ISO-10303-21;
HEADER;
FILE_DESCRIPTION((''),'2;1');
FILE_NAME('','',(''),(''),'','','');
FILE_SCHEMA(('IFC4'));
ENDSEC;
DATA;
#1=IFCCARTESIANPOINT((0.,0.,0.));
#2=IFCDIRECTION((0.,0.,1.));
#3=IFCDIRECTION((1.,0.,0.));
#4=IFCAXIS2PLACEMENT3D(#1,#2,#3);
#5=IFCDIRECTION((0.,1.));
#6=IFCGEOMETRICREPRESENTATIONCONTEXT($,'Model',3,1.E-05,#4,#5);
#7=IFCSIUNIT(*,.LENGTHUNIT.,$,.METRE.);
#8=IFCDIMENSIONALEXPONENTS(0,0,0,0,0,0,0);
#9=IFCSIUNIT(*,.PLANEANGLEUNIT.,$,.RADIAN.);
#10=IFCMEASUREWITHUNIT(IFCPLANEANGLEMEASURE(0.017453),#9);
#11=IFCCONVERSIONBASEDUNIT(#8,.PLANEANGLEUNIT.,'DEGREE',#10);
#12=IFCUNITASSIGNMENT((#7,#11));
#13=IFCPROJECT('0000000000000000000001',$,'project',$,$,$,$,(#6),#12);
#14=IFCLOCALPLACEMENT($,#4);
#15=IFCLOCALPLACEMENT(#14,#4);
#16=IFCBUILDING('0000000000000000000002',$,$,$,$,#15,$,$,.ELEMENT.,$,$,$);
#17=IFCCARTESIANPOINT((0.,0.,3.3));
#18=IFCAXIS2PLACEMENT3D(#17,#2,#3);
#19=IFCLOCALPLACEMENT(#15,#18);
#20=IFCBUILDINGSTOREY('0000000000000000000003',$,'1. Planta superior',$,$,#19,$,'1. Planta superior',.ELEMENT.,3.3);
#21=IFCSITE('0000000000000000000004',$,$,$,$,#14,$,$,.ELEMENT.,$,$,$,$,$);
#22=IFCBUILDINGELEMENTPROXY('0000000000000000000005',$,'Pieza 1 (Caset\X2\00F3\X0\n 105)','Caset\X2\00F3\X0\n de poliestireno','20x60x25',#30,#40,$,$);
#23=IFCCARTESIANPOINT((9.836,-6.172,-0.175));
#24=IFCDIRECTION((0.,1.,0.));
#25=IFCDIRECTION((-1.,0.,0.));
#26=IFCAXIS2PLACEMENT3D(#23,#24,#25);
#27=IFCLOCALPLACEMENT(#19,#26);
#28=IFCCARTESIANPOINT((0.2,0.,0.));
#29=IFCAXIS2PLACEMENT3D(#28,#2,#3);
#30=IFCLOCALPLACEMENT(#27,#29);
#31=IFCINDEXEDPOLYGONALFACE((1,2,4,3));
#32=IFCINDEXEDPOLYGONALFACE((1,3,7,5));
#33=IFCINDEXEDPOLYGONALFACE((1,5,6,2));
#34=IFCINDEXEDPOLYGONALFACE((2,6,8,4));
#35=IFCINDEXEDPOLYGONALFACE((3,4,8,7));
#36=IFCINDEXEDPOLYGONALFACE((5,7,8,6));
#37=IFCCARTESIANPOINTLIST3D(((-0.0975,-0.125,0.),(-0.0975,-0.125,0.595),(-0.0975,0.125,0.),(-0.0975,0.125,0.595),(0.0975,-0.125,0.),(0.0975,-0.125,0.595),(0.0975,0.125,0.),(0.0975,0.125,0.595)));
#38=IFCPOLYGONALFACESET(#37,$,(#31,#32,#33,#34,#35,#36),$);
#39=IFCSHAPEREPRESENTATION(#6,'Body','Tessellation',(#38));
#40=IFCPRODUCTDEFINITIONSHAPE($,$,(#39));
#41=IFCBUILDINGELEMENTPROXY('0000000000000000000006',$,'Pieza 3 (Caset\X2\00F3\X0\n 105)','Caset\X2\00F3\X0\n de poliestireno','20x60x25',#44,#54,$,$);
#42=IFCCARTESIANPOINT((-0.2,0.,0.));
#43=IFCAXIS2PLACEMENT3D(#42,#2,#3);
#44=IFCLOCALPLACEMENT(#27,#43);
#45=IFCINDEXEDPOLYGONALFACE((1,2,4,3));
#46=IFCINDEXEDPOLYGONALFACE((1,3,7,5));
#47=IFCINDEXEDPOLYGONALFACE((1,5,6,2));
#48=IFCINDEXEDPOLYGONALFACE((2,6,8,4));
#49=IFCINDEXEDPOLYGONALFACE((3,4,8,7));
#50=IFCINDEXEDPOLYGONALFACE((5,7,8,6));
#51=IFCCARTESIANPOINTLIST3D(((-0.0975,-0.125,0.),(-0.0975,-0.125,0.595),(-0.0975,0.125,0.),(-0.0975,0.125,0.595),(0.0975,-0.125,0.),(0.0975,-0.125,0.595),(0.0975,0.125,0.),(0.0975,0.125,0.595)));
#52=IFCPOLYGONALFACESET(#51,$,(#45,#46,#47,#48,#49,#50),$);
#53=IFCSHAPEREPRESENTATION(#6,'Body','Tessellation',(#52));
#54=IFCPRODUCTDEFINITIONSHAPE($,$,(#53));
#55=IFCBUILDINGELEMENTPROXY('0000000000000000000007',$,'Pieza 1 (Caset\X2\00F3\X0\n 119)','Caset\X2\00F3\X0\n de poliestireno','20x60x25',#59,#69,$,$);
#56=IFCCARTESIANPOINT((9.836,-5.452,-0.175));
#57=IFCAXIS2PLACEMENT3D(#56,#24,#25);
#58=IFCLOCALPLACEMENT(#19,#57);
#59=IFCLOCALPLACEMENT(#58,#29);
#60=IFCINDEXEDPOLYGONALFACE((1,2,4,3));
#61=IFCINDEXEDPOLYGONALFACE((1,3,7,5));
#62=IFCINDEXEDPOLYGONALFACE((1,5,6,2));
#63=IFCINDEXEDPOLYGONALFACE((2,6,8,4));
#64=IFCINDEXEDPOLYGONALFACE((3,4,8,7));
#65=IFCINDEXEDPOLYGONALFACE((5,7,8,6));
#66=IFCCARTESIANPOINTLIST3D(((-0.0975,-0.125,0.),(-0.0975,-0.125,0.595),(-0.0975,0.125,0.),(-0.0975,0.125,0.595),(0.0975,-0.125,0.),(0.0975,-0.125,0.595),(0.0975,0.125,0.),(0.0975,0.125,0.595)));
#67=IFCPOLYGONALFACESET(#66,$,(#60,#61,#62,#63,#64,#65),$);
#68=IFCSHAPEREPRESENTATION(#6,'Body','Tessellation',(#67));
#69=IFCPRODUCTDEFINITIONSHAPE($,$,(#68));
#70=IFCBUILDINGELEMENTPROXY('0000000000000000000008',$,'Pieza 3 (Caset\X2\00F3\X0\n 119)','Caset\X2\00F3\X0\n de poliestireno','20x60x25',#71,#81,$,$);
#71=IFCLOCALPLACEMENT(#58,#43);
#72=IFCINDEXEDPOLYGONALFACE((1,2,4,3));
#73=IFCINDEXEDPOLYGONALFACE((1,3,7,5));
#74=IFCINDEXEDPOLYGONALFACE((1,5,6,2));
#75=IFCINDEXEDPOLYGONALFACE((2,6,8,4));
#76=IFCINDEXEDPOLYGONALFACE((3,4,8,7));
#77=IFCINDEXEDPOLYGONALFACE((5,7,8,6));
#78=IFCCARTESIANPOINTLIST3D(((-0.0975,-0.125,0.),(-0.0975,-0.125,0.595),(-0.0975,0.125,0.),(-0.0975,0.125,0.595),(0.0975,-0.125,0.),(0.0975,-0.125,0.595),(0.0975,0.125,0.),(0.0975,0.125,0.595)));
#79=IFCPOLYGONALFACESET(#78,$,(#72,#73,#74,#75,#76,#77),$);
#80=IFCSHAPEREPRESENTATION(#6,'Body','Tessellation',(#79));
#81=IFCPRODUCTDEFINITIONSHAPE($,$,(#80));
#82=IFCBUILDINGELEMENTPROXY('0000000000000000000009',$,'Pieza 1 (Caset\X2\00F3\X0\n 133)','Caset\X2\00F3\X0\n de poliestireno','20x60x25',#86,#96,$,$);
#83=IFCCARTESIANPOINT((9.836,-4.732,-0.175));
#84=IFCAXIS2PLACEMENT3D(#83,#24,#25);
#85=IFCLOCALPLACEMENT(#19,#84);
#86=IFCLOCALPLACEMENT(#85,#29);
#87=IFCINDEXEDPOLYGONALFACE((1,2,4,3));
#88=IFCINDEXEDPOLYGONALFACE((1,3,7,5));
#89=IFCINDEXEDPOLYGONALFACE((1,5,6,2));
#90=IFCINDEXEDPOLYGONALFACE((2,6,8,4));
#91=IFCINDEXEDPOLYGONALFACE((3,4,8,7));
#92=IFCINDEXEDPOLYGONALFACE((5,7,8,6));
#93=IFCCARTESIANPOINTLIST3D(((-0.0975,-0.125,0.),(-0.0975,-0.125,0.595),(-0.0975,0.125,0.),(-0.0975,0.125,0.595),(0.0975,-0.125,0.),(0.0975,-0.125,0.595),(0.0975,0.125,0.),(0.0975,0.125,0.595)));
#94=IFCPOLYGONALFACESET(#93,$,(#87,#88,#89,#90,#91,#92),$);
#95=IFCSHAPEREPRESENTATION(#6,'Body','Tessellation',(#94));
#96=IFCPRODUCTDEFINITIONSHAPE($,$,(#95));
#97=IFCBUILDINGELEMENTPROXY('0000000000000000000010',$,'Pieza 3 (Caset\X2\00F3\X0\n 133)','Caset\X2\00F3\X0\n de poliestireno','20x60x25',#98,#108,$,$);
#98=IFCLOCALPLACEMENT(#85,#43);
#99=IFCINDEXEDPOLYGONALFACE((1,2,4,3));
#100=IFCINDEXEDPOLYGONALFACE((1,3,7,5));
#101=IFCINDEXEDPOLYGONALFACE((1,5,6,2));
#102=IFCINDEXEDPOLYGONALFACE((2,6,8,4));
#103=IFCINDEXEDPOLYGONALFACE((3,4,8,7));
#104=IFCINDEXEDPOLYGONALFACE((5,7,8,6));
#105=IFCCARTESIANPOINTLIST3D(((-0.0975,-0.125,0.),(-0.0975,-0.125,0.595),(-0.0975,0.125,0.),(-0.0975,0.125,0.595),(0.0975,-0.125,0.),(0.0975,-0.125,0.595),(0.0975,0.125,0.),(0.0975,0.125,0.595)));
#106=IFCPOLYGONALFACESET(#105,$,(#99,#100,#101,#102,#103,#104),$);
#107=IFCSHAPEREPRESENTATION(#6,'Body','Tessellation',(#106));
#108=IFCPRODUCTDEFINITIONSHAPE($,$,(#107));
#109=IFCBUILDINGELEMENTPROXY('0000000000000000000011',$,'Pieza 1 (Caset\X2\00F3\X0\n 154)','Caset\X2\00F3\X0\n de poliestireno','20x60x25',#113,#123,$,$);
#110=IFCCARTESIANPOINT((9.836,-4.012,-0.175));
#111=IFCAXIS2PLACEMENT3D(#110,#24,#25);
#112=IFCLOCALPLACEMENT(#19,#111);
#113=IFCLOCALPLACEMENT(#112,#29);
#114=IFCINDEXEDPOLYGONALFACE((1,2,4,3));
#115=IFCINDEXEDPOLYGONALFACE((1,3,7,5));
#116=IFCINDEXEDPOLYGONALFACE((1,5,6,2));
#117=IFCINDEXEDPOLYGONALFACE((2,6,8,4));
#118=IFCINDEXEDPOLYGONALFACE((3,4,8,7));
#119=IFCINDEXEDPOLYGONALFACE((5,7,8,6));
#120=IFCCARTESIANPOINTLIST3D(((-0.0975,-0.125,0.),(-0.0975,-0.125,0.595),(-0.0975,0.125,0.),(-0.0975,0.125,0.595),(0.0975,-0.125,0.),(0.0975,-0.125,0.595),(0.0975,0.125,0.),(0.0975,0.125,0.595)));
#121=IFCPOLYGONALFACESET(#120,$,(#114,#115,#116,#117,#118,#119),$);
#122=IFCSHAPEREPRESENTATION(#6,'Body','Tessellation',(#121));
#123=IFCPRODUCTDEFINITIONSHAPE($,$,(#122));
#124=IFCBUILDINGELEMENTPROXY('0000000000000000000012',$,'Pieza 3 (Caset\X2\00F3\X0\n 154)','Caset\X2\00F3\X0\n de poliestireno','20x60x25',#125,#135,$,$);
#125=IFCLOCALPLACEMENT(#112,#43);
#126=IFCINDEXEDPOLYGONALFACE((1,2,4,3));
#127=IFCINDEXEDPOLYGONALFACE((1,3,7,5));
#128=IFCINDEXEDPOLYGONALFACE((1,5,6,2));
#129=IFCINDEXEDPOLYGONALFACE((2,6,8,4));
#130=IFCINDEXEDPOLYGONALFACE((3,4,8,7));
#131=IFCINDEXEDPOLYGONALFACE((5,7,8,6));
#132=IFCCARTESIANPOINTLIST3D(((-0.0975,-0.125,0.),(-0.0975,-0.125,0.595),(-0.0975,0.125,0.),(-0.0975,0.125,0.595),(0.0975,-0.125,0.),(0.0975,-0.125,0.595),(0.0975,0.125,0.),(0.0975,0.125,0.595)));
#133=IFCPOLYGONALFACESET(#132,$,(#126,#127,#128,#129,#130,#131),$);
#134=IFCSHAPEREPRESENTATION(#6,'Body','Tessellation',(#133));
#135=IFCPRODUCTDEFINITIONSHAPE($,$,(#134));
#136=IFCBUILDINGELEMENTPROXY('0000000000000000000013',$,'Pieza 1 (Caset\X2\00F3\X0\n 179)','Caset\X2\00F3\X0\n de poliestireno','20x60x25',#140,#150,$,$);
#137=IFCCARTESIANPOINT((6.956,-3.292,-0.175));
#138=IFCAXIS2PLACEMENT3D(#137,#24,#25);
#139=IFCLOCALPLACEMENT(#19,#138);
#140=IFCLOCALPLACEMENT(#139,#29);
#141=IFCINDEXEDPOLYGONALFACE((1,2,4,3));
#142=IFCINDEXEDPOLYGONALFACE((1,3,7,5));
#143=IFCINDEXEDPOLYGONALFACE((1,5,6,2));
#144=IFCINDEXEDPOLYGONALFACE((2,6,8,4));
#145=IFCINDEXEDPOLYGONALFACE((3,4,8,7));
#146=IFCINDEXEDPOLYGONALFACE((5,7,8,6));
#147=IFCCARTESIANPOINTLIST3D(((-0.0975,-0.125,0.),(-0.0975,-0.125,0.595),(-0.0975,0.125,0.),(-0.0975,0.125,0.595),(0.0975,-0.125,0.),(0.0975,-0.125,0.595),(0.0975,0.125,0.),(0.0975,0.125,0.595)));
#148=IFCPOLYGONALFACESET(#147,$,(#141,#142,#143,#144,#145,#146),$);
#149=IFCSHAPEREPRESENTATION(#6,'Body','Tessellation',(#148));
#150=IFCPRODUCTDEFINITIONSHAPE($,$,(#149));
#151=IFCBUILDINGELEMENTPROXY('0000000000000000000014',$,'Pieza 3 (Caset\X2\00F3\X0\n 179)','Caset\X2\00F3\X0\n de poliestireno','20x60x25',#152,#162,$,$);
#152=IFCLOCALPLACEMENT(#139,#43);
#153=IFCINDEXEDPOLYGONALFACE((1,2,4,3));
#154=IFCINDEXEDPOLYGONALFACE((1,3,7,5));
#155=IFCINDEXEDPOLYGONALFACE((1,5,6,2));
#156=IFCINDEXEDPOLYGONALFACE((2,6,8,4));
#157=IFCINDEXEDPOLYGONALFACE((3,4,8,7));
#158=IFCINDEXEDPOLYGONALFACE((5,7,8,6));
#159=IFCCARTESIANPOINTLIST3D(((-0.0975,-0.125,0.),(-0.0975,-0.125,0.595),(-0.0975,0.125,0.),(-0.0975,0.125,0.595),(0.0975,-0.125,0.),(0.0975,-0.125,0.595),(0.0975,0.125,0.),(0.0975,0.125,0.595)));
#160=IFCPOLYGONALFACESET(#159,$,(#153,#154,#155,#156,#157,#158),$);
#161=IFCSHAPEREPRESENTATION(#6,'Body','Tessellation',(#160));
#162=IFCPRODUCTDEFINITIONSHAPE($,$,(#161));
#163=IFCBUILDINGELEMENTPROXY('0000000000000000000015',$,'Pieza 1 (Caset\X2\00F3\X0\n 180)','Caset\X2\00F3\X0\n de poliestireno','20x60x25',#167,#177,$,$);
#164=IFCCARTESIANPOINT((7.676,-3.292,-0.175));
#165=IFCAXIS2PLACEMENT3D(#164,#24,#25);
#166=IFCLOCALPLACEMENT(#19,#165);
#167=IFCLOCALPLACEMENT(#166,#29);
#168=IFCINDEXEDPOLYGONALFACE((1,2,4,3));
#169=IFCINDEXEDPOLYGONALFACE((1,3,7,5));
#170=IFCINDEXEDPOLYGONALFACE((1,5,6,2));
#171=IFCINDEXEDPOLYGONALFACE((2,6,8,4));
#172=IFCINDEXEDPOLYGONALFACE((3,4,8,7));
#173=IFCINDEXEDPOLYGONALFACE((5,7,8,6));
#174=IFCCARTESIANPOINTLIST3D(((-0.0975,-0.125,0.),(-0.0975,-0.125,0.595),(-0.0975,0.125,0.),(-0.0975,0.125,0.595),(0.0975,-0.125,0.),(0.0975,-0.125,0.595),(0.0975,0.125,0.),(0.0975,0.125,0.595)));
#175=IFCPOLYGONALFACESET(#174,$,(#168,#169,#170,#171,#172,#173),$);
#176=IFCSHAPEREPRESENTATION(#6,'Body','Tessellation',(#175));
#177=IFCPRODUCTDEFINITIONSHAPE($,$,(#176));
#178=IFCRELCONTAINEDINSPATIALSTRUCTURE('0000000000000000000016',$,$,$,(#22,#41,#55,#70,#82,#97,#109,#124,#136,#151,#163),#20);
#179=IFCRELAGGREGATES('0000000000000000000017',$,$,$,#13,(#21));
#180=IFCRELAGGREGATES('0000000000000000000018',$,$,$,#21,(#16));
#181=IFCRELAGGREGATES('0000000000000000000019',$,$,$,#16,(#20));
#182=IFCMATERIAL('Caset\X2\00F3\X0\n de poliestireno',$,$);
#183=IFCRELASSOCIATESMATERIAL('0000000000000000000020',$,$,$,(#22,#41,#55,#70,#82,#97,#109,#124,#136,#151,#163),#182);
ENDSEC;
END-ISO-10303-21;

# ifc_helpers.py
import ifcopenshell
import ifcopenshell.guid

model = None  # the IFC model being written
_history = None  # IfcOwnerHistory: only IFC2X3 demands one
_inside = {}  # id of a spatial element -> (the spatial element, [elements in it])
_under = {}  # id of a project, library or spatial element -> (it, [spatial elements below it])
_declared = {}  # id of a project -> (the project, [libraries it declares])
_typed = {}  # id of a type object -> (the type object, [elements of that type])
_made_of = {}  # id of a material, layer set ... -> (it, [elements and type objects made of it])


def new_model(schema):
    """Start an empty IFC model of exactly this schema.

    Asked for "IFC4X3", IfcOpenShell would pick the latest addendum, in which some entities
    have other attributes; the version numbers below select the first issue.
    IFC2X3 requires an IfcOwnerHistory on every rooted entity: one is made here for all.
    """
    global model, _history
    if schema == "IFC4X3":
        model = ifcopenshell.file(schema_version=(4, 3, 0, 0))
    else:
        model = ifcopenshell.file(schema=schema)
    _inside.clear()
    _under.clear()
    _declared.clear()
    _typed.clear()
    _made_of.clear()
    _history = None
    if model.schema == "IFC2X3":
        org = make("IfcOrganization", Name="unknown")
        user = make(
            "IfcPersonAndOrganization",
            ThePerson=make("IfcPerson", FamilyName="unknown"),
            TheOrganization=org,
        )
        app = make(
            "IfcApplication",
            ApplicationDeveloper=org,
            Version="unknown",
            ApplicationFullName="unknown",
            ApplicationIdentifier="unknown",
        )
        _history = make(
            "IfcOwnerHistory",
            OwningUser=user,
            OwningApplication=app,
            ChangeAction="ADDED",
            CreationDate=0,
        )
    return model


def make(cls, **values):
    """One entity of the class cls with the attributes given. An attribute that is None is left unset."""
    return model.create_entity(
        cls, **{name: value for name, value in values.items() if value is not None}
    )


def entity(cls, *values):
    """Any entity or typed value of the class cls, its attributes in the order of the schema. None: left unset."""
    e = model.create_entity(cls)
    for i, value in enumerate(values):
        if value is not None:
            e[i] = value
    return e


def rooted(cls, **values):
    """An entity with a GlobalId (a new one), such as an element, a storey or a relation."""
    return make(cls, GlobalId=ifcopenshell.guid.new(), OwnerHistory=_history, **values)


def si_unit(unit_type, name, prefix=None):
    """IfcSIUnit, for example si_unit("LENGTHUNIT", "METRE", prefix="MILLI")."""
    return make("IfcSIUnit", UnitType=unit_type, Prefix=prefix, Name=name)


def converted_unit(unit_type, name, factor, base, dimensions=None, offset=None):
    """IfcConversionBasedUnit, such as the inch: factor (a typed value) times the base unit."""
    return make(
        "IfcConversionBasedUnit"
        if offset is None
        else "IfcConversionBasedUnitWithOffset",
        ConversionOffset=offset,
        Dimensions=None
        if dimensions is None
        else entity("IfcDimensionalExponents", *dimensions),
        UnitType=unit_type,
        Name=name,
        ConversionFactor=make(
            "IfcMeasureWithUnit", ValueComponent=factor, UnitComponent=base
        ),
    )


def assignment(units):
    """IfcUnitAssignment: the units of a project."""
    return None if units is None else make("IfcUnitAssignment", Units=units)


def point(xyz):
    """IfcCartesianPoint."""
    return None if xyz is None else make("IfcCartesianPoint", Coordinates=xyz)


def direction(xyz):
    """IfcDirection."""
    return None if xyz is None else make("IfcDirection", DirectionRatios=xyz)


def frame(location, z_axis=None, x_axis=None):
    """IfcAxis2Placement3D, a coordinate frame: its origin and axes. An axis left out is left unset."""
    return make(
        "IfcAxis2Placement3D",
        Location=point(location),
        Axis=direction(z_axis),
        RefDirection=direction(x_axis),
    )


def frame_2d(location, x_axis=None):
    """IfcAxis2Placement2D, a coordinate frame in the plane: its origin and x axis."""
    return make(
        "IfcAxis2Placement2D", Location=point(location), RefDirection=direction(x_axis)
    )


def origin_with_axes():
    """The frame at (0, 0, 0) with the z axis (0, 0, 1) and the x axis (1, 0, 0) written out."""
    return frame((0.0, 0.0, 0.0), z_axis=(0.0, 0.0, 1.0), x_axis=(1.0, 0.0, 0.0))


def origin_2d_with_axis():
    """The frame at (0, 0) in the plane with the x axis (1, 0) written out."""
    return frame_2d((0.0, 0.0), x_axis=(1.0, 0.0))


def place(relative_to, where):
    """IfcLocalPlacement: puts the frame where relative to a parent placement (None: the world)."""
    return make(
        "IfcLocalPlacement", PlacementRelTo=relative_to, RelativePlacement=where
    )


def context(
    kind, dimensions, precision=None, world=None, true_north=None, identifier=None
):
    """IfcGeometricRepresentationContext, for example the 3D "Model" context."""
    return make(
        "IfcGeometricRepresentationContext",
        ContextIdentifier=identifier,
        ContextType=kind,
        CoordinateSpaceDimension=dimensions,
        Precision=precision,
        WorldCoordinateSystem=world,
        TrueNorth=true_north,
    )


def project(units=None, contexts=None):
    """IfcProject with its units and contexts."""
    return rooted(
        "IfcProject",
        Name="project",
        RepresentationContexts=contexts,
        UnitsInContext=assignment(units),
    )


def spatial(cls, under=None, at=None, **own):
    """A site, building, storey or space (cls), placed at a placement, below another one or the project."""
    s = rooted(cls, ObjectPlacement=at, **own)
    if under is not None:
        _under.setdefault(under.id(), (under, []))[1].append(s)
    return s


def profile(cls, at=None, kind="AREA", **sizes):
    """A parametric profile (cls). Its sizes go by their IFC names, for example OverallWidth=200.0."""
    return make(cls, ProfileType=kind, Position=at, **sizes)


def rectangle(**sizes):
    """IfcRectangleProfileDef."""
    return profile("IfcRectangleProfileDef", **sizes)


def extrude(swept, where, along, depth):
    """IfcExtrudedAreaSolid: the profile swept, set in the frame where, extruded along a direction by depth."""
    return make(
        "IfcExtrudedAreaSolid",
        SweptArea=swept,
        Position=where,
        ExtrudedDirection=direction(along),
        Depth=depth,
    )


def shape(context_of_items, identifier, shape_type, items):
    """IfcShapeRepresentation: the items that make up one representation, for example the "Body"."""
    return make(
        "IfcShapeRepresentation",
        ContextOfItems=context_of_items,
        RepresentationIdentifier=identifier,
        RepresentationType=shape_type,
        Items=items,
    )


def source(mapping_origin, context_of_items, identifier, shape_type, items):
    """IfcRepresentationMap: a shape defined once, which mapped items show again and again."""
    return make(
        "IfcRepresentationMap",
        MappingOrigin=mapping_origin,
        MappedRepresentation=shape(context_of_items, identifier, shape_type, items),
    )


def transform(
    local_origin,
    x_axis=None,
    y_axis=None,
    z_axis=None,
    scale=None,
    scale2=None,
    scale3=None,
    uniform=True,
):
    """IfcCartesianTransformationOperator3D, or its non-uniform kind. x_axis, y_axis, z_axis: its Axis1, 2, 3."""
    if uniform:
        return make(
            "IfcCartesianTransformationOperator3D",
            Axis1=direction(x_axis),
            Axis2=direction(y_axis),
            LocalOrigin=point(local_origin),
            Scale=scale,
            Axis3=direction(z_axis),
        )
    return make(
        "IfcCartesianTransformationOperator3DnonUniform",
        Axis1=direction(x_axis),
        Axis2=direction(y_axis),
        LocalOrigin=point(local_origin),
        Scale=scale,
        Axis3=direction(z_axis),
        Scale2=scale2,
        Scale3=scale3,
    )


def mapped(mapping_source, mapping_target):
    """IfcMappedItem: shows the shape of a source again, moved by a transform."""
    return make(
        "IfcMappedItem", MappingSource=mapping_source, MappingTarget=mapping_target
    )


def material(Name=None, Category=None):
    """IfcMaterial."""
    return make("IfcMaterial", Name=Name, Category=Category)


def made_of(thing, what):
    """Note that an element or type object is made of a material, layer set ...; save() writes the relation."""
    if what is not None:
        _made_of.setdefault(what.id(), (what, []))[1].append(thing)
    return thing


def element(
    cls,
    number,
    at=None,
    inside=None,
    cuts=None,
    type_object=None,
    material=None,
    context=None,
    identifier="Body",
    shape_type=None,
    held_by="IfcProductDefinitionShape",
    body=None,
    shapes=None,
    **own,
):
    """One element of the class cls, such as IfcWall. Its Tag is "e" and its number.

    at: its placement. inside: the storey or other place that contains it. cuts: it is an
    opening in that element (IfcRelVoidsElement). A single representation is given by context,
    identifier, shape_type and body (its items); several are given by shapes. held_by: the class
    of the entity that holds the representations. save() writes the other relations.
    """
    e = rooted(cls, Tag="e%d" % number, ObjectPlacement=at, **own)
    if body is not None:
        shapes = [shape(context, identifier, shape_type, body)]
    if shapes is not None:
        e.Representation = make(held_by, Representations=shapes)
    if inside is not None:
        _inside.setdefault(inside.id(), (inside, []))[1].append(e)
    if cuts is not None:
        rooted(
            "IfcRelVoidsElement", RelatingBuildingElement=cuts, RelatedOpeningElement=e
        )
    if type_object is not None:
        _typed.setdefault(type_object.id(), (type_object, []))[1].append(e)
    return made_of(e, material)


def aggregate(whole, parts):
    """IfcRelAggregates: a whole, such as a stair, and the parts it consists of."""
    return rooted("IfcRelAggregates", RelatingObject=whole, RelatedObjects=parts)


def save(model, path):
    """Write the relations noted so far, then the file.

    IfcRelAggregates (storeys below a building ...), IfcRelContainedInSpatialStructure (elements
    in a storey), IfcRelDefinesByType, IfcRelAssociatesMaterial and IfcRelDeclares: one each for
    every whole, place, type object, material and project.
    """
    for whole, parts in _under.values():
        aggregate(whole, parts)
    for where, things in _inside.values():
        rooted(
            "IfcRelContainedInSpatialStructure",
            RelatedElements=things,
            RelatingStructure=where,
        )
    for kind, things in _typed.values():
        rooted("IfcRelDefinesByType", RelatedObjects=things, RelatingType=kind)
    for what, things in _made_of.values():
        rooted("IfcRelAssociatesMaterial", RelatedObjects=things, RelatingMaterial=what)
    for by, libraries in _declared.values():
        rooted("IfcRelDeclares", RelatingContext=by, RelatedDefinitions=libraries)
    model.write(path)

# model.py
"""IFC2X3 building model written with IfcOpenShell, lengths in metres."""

from ifc_helpers import new_model, entity, si_unit, converted_unit, direction, frame, origin_with_axes, origin_2d_with_axis, place, context, project, spatial, rectangle, extrude, source, transform, mapped, material, element, save


model = new_model("IFC2X3")

# Units and contexts
model_context = context("Model", 3, precision=1e-05, world=origin_with_axes(), true_north=direction((0.0, 1.0)))
ifc_project = project(units=[si_unit("LENGTHUNIT", "METRE"), converted_unit("PLANEANGLEUNIT", "DEGREE", entity("IfcPlaneAngleMeasure", 0.017453), si_unit("PLANEANGLEUNIT", "RADIAN"), dimensions=[0, 0, 0, 0, 0, 0, 0])], contexts=[model_context])

# Site, building, storey
site_placement = place(None, origin_with_axes())
site = spatial("IfcSite", under=ifc_project, at=site_placement, CompositionType="ELEMENT")
building_placement = place(site_placement, origin_with_axes())
building = spatial("IfcBuilding", under=site, at=building_placement, CompositionType="ELEMENT")
storey_placement = place(building_placement, frame((0.0, 0.0, 3.3), z_axis=(0.0, 0.0, 1.0), x_axis=(1.0, 0.0, 0.0)))
storey = spatial("IfcBuildingStorey", under=building, at=storey_placement, Name="1. Planta superior", LongName="1. Planta superior", CompositionType="ELEMENT", Elevation=3.3)

# Building element proxies
ifc_material_1 = material(Name="Casetón de poliestireno")
shared_shape = source(origin_with_axes(), model_context, "Body", "SweptSolid", [
    extrude(rectangle(XDim=0.195, YDim=0.25, at=origin_2d_with_axis()), origin_with_axes(), (0.0, 0.0, 1.0), 0.595),
])
placement_1 = place(storey_placement, frame((9.836, -6.172, -0.175), z_axis=(0.0, 1.0, 0.0), x_axis=(-1.0, 0.0, 0.0)))
for number, where, z_axis, x_axis, name in (
    (1, (0.2, 0.0, 0.0), (0.0, 0.0, 1.0), (1.0, 0.0, 0.0), "Pieza 1 (Casetón 105)"),
    (2, (-0.2, 0.0, 0.0), (0.0, 0.0, 1.0), (1.0, 0.0, 0.0), "Pieza 3 (Casetón 105)"),
):
    element("IfcBuildingElementProxy", number, at=place(placement_1, frame(where, z_axis=z_axis, x_axis=x_axis)), inside=storey, material=ifc_material_1, Name=name, Description="Casetón de poliestireno", ObjectType="20x60x25", context=model_context, shape_type="MappedRepresentation", body=[
        mapped(shared_shape, transform((0.0, 0.0, 0.0), x_axis=(1.0, 0.0, 0.0), y_axis=(0.0, 1.0, 0.0), z_axis=(0.0, 0.0, 1.0))),
    ])
placement_2 = place(storey_placement, frame((9.836, -5.452, -0.175), z_axis=(0.0, 1.0, 0.0), x_axis=(-1.0, 0.0, 0.0)))
for number, where, z_axis, x_axis, name in (
    (3, (0.2, 0.0, 0.0), (0.0, 0.0, 1.0), (1.0, 0.0, 0.0), "Pieza 1 (Casetón 119)"),
    (4, (-0.2, 0.0, 0.0), (0.0, 0.0, 1.0), (1.0, 0.0, 0.0), "Pieza 3 (Casetón 119)"),
):
    element("IfcBuildingElementProxy", number, at=place(placement_2, frame(where, z_axis=z_axis, x_axis=x_axis)), inside=storey, material=ifc_material_1, Name=name, Description="Casetón de poliestireno", ObjectType="20x60x25", context=model_context, shape_type="MappedRepresentation", body=[
        mapped(shared_shape, transform((0.0, 0.0, 0.0), x_axis=(1.0, 0.0, 0.0), y_axis=(0.0, 1.0, 0.0), z_axis=(0.0, 0.0, 1.0))),
    ])
placement_3 = place(storey_placement, frame((9.836, -4.732, -0.175), z_axis=(0.0, 1.0, 0.0), x_axis=(-1.0, 0.0, 0.0)))
for number, where, z_axis, x_axis, name in (
    (5, (0.2, 0.0, 0.0), (0.0, 0.0, 1.0), (1.0, 0.0, 0.0), "Pieza 1 (Casetón 133)"),
    (6, (-0.2, 0.0, 0.0), (0.0, 0.0, 1.0), (1.0, 0.0, 0.0), "Pieza 3 (Casetón 133)"),
):
    element("IfcBuildingElementProxy", number, at=place(placement_3, frame(where, z_axis=z_axis, x_axis=x_axis)), inside=storey, material=ifc_material_1, Name=name, Description="Casetón de poliestireno", ObjectType="20x60x25", context=model_context, shape_type="MappedRepresentation", body=[
        mapped(shared_shape, transform((0.0, 0.0, 0.0), x_axis=(1.0, 0.0, 0.0), y_axis=(0.0, 1.0, 0.0), z_axis=(0.0, 0.0, 1.0))),
    ])
placement_4 = place(storey_placement, frame((9.836, -4.012, -0.175), z_axis=(0.0, 1.0, 0.0), x_axis=(-1.0, 0.0, 0.0)))
for number, where, z_axis, x_axis, name in (
    (7, (0.2, 0.0, 0.0), (0.0, 0.0, 1.0), (1.0, 0.0, 0.0), "Pieza 1 (Casetón 154)"),
    (8, (-0.2, 0.0, 0.0), (0.0, 0.0, 1.0), (1.0, 0.0, 0.0), "Pieza 3 (Casetón 154)"),
):
    element("IfcBuildingElementProxy", number, at=place(placement_4, frame(where, z_axis=z_axis, x_axis=x_axis)), inside=storey, material=ifc_material_1, Name=name, Description="Casetón de poliestireno", ObjectType="20x60x25", context=model_context, shape_type="MappedRepresentation", body=[
        mapped(shared_shape, transform((0.0, 0.0, 0.0), x_axis=(1.0, 0.0, 0.0), y_axis=(0.0, 1.0, 0.0), z_axis=(0.0, 0.0, 1.0))),
    ])
placement_5 = place(storey_placement, frame((6.956, -3.292, -0.175), z_axis=(0.0, 1.0, 0.0), x_axis=(-1.0, 0.0, 0.0)))
for number, where, z_axis, x_axis, name in (
    (9, (0.2, 0.0, 0.0), (0.0, 0.0, 1.0), (1.0, 0.0, 0.0), "Pieza 1 (Casetón 179)"),
    (10, (-0.2, 0.0, 0.0), (0.0, 0.0, 1.0), (1.0, 0.0, 0.0), "Pieza 3 (Casetón 179)"),
):
    element("IfcBuildingElementProxy", number, at=place(placement_5, frame(where, z_axis=z_axis, x_axis=x_axis)), inside=storey, material=ifc_material_1, Name=name, Description="Casetón de poliestireno", ObjectType="20x60x25", context=model_context, shape_type="MappedRepresentation", body=[
        mapped(shared_shape, transform((0.0, 0.0, 0.0), x_axis=(1.0, 0.0, 0.0), y_axis=(0.0, 1.0, 0.0), z_axis=(0.0, 0.0, 1.0))),
    ])
placement_6 = place(storey_placement, frame((7.676, -3.292, -0.175), z_axis=(0.0, 1.0, 0.0), x_axis=(-1.0, 0.0, 0.0)))
for number, where, z_axis, x_axis, name in (
    (11, (0.2, 0.0, 0.0), (0.0, 0.0, 1.0), (1.0, 0.0, 0.0), "Pieza 1 (Casetón 180)"),
):
    element("IfcBuildingElementProxy", number, at=place(placement_6, frame(where, z_axis=z_axis, x_axis=x_axis)), inside=storey, material=ifc_material_1, Name=name, Description="Casetón de poliestireno", ObjectType="20x60x25", context=model_context, shape_type="MappedRepresentation", body=[
        mapped(shared_shape, transform((0.0, 0.0, 0.0), x_axis=(1.0, 0.0, 0.0), y_axis=(0.0, 1.0, 0.0), z_axis=(0.0, 0.0, 1.0))),
    ])

save(model, "model.ifc")
